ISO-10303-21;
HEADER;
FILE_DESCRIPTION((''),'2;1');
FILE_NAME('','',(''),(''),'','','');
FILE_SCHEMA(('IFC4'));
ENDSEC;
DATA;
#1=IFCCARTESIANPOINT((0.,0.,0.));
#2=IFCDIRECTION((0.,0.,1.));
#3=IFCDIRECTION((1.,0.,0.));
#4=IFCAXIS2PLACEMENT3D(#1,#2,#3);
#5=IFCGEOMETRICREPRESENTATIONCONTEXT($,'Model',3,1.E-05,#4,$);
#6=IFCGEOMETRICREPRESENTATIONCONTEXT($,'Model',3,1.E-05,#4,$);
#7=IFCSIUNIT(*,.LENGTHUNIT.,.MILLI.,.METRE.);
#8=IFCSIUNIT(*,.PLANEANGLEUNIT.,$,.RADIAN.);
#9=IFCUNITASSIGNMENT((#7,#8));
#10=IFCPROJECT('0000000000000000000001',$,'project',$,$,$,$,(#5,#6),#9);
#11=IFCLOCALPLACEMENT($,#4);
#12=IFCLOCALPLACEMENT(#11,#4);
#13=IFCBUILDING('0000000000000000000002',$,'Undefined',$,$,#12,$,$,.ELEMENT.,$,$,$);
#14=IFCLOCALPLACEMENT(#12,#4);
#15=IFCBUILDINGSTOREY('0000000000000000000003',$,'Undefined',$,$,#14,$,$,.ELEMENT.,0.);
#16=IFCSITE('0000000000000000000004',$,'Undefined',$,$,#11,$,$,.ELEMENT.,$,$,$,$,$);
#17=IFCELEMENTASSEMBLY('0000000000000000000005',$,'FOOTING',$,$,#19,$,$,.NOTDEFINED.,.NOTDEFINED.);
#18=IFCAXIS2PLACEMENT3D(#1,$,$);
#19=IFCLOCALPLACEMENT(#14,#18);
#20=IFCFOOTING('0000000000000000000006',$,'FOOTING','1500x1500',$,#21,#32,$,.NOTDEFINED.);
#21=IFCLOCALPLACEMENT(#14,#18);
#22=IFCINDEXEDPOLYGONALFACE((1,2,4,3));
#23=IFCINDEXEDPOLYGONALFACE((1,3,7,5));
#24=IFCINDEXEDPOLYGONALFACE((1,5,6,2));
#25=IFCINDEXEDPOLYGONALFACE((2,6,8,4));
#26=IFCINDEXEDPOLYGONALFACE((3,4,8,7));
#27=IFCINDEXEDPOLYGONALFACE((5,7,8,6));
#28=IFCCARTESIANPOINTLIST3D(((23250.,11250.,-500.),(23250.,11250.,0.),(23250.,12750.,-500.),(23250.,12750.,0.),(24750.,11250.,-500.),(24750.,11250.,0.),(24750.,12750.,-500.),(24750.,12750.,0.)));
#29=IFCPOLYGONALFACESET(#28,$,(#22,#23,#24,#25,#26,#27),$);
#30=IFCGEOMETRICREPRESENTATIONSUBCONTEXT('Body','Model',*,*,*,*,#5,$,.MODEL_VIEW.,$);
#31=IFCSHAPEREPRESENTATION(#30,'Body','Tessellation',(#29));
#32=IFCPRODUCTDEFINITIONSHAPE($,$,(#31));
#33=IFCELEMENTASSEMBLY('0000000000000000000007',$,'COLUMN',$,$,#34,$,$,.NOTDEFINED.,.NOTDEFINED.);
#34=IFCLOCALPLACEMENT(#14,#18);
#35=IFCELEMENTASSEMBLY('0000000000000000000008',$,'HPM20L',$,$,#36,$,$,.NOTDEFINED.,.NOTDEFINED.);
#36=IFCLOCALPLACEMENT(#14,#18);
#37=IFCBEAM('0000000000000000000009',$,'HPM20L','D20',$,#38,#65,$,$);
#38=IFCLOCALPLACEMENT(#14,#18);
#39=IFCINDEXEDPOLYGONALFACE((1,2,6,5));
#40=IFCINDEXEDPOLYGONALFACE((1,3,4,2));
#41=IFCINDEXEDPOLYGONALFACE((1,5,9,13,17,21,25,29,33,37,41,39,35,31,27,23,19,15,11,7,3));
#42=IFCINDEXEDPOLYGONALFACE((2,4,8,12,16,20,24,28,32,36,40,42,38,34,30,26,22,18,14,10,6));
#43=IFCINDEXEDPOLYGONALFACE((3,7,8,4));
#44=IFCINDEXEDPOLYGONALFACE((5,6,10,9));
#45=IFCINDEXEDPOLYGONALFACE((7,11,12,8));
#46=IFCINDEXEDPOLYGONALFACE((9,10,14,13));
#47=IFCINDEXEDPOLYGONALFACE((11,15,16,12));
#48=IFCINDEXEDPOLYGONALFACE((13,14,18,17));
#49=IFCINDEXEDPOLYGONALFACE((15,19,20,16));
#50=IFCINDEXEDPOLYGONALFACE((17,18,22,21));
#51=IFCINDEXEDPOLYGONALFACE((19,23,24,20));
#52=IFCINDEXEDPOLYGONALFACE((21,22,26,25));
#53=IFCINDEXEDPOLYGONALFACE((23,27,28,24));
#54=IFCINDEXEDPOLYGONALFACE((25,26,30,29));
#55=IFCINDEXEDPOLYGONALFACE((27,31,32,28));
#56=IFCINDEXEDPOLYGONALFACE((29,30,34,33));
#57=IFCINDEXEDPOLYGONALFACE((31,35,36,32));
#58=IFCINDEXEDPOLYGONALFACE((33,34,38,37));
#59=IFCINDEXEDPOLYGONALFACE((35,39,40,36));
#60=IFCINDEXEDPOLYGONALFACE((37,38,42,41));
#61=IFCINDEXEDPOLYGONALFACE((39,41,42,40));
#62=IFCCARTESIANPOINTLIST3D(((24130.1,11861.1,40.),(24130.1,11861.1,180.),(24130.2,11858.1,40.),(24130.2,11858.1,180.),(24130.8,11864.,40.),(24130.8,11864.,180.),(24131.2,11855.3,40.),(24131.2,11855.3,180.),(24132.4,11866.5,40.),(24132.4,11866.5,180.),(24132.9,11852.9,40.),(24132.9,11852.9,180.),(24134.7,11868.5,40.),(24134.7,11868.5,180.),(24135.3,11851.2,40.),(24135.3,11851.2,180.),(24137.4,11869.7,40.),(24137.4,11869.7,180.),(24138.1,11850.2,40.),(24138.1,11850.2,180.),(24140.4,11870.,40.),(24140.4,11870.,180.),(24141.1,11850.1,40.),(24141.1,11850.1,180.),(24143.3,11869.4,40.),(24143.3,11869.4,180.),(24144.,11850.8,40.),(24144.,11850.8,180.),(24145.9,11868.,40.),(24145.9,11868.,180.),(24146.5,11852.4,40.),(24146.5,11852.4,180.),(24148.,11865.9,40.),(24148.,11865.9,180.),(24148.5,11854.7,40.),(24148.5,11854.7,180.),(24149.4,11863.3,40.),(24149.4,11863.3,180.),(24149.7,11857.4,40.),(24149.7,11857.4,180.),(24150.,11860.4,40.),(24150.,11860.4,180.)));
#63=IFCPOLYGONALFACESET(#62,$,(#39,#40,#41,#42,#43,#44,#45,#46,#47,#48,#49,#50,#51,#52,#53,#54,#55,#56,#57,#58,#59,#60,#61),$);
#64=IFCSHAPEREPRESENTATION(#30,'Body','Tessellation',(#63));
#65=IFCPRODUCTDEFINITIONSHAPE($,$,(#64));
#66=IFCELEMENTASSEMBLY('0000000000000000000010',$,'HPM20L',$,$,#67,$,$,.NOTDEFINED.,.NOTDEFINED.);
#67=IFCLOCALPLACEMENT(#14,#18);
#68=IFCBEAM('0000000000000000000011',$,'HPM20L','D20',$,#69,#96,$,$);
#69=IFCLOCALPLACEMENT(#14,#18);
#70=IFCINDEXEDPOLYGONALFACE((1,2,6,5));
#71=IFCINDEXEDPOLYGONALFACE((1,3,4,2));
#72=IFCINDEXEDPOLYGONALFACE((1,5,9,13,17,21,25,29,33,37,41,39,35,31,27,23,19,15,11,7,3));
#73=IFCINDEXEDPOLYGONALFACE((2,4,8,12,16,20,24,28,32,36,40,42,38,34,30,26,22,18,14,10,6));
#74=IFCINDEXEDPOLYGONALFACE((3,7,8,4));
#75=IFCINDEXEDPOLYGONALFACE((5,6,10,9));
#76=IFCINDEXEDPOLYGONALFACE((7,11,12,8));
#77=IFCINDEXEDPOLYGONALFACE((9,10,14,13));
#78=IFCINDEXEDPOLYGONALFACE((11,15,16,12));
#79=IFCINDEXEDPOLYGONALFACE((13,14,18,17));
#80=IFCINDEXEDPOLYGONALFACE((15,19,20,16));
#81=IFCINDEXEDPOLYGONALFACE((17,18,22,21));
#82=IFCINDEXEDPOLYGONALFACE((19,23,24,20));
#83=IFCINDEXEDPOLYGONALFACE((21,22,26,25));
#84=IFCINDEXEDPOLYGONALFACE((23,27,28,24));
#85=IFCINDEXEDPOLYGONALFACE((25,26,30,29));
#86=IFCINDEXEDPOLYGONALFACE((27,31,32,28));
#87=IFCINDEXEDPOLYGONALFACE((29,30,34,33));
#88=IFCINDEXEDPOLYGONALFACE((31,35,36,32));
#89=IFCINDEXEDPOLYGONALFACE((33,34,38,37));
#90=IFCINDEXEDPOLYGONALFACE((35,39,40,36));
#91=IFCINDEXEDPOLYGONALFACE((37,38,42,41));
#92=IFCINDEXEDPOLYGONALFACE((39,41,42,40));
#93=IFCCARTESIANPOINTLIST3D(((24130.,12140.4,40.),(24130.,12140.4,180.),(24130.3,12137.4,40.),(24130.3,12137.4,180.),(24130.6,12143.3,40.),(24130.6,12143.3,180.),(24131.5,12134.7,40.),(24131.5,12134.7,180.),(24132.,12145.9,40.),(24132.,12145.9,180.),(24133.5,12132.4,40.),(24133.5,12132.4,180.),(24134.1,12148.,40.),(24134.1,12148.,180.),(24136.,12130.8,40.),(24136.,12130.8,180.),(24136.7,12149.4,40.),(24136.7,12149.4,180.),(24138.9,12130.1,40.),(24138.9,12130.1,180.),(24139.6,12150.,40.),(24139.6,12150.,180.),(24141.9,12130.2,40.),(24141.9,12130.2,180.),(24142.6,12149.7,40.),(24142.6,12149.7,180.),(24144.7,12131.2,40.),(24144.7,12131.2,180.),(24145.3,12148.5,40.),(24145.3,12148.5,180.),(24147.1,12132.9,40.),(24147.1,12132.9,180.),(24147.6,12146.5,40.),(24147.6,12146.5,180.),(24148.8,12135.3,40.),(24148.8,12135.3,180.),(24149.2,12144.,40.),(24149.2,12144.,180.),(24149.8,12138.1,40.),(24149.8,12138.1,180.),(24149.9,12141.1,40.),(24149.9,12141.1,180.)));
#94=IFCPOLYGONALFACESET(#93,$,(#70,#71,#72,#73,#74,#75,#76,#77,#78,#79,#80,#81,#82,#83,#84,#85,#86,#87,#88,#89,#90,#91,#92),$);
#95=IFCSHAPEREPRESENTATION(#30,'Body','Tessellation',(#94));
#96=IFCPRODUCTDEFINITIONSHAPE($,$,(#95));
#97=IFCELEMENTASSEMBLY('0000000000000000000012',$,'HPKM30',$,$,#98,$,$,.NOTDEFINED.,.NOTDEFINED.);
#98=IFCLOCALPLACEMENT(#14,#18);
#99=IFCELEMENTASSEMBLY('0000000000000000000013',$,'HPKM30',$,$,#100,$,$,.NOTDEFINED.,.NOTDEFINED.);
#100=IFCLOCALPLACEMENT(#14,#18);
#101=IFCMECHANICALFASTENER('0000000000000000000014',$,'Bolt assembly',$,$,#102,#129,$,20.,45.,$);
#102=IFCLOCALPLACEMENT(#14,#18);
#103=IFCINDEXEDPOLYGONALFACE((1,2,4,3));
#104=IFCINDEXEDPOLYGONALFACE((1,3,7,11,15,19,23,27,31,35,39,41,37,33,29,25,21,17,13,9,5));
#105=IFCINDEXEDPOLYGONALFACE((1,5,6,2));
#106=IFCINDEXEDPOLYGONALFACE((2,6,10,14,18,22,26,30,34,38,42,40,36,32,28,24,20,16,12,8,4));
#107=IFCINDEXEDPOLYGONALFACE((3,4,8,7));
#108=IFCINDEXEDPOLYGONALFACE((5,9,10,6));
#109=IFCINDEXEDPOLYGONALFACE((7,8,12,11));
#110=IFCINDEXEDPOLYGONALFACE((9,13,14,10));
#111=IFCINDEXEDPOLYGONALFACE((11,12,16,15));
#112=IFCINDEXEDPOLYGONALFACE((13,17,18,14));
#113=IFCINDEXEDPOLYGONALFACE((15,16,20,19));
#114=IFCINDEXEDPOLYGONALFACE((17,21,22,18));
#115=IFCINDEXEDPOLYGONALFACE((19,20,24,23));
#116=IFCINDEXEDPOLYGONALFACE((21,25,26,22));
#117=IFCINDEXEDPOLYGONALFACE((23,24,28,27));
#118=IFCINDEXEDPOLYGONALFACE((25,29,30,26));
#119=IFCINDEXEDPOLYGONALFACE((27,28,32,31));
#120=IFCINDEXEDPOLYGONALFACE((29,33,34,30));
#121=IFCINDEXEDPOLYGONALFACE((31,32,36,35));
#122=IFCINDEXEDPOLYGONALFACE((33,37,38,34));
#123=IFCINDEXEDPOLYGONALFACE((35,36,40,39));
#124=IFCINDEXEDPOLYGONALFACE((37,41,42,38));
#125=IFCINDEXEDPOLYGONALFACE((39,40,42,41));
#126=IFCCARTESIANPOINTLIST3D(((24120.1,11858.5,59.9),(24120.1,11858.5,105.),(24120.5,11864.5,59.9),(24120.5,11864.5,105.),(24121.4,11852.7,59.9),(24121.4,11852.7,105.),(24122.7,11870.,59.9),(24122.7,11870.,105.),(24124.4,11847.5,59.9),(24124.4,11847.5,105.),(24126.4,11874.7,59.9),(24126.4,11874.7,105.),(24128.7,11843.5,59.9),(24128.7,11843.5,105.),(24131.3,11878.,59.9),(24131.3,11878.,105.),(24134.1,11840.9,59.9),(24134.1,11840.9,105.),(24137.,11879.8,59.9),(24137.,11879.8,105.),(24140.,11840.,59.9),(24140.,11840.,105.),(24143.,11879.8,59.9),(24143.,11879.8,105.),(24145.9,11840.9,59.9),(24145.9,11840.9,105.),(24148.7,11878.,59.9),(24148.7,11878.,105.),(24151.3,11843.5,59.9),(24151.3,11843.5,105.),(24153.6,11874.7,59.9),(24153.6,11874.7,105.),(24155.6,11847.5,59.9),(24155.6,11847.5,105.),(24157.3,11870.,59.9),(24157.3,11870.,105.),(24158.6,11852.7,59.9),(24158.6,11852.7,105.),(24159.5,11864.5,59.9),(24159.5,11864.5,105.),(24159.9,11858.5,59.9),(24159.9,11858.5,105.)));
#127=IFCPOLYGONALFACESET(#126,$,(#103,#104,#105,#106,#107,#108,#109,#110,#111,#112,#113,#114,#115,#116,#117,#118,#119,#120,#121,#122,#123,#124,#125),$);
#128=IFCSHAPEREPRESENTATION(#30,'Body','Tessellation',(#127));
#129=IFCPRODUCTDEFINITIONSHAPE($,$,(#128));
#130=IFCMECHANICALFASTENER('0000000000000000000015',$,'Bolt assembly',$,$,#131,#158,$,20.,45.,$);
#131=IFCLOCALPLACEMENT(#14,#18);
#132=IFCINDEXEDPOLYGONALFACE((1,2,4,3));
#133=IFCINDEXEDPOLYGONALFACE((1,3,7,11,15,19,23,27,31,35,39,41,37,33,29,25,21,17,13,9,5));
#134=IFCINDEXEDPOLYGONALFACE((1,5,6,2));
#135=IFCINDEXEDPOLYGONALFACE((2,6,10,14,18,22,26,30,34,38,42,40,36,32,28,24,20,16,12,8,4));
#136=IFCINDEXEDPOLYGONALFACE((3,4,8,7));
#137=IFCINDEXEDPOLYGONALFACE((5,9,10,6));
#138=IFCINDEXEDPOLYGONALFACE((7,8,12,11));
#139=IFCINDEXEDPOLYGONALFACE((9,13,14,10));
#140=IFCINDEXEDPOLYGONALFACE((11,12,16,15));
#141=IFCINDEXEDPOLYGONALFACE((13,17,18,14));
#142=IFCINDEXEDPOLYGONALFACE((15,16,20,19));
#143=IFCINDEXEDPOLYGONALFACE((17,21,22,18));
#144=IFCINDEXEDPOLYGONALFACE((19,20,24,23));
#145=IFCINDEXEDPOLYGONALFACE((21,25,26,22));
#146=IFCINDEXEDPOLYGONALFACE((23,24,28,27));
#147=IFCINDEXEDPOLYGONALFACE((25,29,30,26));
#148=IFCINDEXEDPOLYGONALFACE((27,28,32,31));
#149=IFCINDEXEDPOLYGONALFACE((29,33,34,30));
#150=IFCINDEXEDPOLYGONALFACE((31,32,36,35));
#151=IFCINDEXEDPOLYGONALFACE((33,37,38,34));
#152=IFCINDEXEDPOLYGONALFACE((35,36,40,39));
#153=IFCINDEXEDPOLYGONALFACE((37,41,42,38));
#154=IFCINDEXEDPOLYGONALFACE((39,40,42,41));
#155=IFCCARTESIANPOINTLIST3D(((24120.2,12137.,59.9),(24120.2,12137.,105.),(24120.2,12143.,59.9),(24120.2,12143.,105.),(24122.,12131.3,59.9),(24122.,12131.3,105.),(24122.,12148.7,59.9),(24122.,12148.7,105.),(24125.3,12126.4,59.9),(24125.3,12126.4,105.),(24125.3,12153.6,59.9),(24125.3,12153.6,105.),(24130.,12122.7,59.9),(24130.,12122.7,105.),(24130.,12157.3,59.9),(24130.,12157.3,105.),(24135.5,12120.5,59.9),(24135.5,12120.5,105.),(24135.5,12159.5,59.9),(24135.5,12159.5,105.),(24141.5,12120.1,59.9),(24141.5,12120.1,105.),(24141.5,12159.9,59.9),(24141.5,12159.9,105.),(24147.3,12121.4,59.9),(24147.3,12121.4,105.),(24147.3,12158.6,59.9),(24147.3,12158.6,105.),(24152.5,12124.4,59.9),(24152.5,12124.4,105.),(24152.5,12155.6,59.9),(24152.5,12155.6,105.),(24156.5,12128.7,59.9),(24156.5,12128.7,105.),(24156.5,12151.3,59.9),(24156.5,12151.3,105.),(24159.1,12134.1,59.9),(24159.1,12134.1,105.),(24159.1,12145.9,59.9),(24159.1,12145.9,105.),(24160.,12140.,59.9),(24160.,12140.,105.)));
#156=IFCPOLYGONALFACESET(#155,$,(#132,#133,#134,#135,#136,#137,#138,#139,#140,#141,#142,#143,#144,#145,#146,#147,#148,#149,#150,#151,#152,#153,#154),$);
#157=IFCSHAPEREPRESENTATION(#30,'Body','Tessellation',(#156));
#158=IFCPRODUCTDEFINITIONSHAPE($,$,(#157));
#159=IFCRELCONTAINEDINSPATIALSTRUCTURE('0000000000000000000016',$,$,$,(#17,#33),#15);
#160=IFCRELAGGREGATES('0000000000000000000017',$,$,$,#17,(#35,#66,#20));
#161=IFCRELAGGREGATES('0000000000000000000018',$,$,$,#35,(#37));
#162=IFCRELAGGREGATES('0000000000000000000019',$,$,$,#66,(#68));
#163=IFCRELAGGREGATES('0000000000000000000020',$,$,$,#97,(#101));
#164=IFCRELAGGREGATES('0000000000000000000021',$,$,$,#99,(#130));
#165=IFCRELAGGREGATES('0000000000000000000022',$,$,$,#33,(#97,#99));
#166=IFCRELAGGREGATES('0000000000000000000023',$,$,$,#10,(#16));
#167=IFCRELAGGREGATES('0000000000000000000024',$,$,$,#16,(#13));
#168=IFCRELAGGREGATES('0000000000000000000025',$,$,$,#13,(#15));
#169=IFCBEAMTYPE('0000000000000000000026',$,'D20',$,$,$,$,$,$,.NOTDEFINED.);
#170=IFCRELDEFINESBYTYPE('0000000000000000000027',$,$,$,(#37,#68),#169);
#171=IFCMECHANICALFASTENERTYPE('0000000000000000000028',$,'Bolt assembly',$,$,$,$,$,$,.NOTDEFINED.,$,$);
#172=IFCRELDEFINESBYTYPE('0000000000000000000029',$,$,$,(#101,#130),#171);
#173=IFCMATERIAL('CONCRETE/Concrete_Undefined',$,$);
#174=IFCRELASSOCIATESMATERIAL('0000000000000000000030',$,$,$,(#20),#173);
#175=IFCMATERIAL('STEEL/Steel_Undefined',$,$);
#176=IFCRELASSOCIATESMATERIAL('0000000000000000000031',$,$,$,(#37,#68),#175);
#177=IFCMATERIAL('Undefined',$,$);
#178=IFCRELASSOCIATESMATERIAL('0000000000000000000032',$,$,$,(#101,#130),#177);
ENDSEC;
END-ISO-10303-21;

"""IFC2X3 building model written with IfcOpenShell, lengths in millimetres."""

from ifc_helpers import new_model, si_unit, frame, origin_with_axes, origin_2d_with_axis, place, context, subcontext, project, spatial, rectangle, circle, extrude, source, transform, mapped, material, type_object, element, aggregate, save


model = new_model("IFC2X3")

# Units and contexts
model_context_1 = context("Model", 3, precision=1e-05, world=origin_with_axes())
model_context_2 = context("Model", 3, precision=1e-05, world=origin_with_axes())
body_context = subcontext(model_context_1, "Body", "Model", "MODEL_VIEW")
ifc_project = project(units=[si_unit("LENGTHUNIT", "METRE", prefix="MILLI"), si_unit("PLANEANGLEUNIT", "RADIAN")], contexts=[model_context_1, model_context_2])

# Site, building, storey
site_placement = place(None, origin_with_axes())
site = spatial("IfcSite", under=ifc_project, at=site_placement, Name="Undefined", CompositionType="ELEMENT")
building_placement = place(site_placement, origin_with_axes())
building = spatial("IfcBuilding", under=site, at=building_placement, Name="Undefined", CompositionType="ELEMENT")
storey_placement = place(building_placement, origin_with_axes())
storey = spatial("IfcBuildingStorey", under=building, at=storey_placement, Name="Undefined", CompositionType="ELEMENT", Elevation=0.0)

# Element assembly, footing
assembly_1_placement = place(storey_placement, origin_with_axes())
assembly_1 = element("IfcElementAssembly", 1, at=assembly_1_placement, inside=storey, Name="FOOTING", AssemblyPlace="NOTDEFINED", PredefinedType="NOTDEFINED")
ifc_material_1 = material(Name="CONCRETE/Concrete_Undefined")
footing_placement = place(assembly_1_placement, frame((24000.0, 12000.0, -500.0), z_axis=(0.0, 1.0, 0.0), x_axis=(0.0, 0.0, 1.0)))
footing = element("IfcFooting", 2, at=footing_placement, material=ifc_material_1, Name="FOOTING", Description="1500x1500", PredefinedType="NOTDEFINED", context=body_context, shape_type="SweptSolid", body=[
    extrude(rectangle(XDim=1500.0, YDim=1500.0, at=origin_2d_with_axis()), frame((500.0, 0.0, 0.0), z_axis=(-1.0, 0.0, 0.0), x_axis=(0.0, -1.0, 0.0)), (0.0, 0.0, 1.0), 500.0),
])

# Element assembly
assembly_2_placement = place(storey_placement, origin_with_axes())
assembly_2 = element("IfcElementAssembly", 3, at=assembly_2_placement, inside=storey, Name="COLUMN", AssemblyPlace="NOTDEFINED", PredefinedType="NOTDEFINED")

# Element assembly, beam
assembly_3_placement = place(assembly_1_placement, origin_with_axes())
assembly_3 = element("IfcElementAssembly", 4, at=assembly_3_placement, Name="HPM20L", AssemblyPlace="NOTDEFINED", PredefinedType="NOTDEFINED")
ifc_material_2 = material(Name="STEEL/Steel_Undefined")
beam_type = type_object("IfcBeamType", Name="D20", PredefinedType="NOTDEFINED")
beam_1_placement = place(assembly_3_placement, frame((24140.0, 11860.0, 180.0), z_axis=(0.707107, -0.707107, 0.0), x_axis=(0.0, 0.0, -1.0)))
beam_1 = element("IfcBeam", 5, at=beam_1_placement, type_object=beam_type, material=ifc_material_2, Name="HPM20L", Description="D20", context=body_context, shape_type="SweptSolid", body=[
    extrude(circle(Radius=10.0, at=origin_2d_with_axis()), frame((140.0, 0.0, 0.0), z_axis=(-1.0, 0.0, 0.0), x_axis=(0.0, -1.0, 0.0)), (0.0, 0.0, 1.0), 140.0),
])

# Element assembly
assembly_4_placement = place(assembly_1_placement, origin_with_axes())
assembly_4 = element("IfcElementAssembly", 6, at=assembly_4_placement, Name="HPM20L", AssemblyPlace="NOTDEFINED", PredefinedType="NOTDEFINED")
aggregate(assembly_1, [assembly_3, assembly_4, footing])

# Beam
beam_2_placement = place(assembly_4_placement, frame((24140.0, 12140.0, 180.0), z_axis=(0.707107, 0.707107, 0.0), x_axis=(0.0, 0.0, -1.0)))
beam_2 = element("IfcBeam", 7, at=beam_2_placement, type_object=beam_type, material=ifc_material_2, Name="HPM20L", Description="D20", context=body_context, shape_type="SweptSolid", body=[
    extrude(circle(Radius=10.0, at=origin_2d_with_axis()), frame((140.0, 0.0, 0.0), z_axis=(-1.0, 0.0, 0.0), x_axis=(0.0, -1.0, 0.0)), (0.0, 0.0, 1.0), 140.0),
])

# Element assemblies
assembly_5_placement = place(assembly_2_placement, origin_with_axes())
assembly_5 = element("IfcElementAssembly", 8, at=assembly_5_placement, Name="HPKM30", AssemblyPlace="NOTDEFINED", PredefinedType="NOTDEFINED")
assembly_6_placement = place(assembly_2_placement, origin_with_axes())
assembly_6 = element("IfcElementAssembly", 9, at=assembly_6_placement, Name="HPKM30", AssemblyPlace="NOTDEFINED", PredefinedType="NOTDEFINED")

# Mechanical fasteners
ifc_material_3 = material(Name="Undefined")
mechanical_fastener_type = type_object("IfcMechanicalFastenerType", Name="Bolt assembly")
shared_shape_1 = source(origin_with_axes(), body_context, "Body", "SweptSolid", [
    extrude(circle(Radius=20.0, at=origin_2d_with_axis()), frame((0.0, -45.0, 0.0), z_axis=(0.0, 1.0, 0.0), x_axis=(1.0, 0.0, 0.0)), (0.0, 0.0, 1.0), 45.1),
])
mechanical_fastener_1_placement = place(assembly_5_placement, frame((24140.0, 11860.0, 60.0), z_axis=(1.0, 0.0, 0.0), x_axis=(0.0, -1.0, 0.0)))
mechanical_fastener_1 = element("IfcMechanicalFastener", 10, at=mechanical_fastener_1_placement, type_object=mechanical_fastener_type, material=ifc_material_3, Name="Bolt assembly", NominalDiameter=20.0, NominalLength=45.0, context=body_context, shape_type="MappedRepresentation", body=[
    mapped(shared_shape_1, transform((0.0, 0.0, 0.0))),
])
mechanical_fastener_2_placement = place(assembly_6_placement, frame((24140.0, 12140.0, 60.0), z_axis=(0.0, 1.0, 0.0), x_axis=(1.0, 0.0, 0.0)))
mechanical_fastener_2 = element("IfcMechanicalFastener", 11, at=mechanical_fastener_2_placement, type_object=mechanical_fastener_type, material=ifc_material_3, Name="Bolt assembly", NominalDiameter=20.0, NominalLength=45.0, context=body_context, shape_type="MappedRepresentation", body=[
    mapped(shared_shape_1, transform((0.0, 0.0, 0.0))),
])

aggregate(assembly_3, [beam_1])
aggregate(assembly_4, [beam_2])
aggregate(assembly_5, [mechanical_fastener_1])
aggregate(assembly_6, [mechanical_fastener_2])
aggregate(assembly_2, [assembly_5, assembly_6])

save(model, "model.ifc")
